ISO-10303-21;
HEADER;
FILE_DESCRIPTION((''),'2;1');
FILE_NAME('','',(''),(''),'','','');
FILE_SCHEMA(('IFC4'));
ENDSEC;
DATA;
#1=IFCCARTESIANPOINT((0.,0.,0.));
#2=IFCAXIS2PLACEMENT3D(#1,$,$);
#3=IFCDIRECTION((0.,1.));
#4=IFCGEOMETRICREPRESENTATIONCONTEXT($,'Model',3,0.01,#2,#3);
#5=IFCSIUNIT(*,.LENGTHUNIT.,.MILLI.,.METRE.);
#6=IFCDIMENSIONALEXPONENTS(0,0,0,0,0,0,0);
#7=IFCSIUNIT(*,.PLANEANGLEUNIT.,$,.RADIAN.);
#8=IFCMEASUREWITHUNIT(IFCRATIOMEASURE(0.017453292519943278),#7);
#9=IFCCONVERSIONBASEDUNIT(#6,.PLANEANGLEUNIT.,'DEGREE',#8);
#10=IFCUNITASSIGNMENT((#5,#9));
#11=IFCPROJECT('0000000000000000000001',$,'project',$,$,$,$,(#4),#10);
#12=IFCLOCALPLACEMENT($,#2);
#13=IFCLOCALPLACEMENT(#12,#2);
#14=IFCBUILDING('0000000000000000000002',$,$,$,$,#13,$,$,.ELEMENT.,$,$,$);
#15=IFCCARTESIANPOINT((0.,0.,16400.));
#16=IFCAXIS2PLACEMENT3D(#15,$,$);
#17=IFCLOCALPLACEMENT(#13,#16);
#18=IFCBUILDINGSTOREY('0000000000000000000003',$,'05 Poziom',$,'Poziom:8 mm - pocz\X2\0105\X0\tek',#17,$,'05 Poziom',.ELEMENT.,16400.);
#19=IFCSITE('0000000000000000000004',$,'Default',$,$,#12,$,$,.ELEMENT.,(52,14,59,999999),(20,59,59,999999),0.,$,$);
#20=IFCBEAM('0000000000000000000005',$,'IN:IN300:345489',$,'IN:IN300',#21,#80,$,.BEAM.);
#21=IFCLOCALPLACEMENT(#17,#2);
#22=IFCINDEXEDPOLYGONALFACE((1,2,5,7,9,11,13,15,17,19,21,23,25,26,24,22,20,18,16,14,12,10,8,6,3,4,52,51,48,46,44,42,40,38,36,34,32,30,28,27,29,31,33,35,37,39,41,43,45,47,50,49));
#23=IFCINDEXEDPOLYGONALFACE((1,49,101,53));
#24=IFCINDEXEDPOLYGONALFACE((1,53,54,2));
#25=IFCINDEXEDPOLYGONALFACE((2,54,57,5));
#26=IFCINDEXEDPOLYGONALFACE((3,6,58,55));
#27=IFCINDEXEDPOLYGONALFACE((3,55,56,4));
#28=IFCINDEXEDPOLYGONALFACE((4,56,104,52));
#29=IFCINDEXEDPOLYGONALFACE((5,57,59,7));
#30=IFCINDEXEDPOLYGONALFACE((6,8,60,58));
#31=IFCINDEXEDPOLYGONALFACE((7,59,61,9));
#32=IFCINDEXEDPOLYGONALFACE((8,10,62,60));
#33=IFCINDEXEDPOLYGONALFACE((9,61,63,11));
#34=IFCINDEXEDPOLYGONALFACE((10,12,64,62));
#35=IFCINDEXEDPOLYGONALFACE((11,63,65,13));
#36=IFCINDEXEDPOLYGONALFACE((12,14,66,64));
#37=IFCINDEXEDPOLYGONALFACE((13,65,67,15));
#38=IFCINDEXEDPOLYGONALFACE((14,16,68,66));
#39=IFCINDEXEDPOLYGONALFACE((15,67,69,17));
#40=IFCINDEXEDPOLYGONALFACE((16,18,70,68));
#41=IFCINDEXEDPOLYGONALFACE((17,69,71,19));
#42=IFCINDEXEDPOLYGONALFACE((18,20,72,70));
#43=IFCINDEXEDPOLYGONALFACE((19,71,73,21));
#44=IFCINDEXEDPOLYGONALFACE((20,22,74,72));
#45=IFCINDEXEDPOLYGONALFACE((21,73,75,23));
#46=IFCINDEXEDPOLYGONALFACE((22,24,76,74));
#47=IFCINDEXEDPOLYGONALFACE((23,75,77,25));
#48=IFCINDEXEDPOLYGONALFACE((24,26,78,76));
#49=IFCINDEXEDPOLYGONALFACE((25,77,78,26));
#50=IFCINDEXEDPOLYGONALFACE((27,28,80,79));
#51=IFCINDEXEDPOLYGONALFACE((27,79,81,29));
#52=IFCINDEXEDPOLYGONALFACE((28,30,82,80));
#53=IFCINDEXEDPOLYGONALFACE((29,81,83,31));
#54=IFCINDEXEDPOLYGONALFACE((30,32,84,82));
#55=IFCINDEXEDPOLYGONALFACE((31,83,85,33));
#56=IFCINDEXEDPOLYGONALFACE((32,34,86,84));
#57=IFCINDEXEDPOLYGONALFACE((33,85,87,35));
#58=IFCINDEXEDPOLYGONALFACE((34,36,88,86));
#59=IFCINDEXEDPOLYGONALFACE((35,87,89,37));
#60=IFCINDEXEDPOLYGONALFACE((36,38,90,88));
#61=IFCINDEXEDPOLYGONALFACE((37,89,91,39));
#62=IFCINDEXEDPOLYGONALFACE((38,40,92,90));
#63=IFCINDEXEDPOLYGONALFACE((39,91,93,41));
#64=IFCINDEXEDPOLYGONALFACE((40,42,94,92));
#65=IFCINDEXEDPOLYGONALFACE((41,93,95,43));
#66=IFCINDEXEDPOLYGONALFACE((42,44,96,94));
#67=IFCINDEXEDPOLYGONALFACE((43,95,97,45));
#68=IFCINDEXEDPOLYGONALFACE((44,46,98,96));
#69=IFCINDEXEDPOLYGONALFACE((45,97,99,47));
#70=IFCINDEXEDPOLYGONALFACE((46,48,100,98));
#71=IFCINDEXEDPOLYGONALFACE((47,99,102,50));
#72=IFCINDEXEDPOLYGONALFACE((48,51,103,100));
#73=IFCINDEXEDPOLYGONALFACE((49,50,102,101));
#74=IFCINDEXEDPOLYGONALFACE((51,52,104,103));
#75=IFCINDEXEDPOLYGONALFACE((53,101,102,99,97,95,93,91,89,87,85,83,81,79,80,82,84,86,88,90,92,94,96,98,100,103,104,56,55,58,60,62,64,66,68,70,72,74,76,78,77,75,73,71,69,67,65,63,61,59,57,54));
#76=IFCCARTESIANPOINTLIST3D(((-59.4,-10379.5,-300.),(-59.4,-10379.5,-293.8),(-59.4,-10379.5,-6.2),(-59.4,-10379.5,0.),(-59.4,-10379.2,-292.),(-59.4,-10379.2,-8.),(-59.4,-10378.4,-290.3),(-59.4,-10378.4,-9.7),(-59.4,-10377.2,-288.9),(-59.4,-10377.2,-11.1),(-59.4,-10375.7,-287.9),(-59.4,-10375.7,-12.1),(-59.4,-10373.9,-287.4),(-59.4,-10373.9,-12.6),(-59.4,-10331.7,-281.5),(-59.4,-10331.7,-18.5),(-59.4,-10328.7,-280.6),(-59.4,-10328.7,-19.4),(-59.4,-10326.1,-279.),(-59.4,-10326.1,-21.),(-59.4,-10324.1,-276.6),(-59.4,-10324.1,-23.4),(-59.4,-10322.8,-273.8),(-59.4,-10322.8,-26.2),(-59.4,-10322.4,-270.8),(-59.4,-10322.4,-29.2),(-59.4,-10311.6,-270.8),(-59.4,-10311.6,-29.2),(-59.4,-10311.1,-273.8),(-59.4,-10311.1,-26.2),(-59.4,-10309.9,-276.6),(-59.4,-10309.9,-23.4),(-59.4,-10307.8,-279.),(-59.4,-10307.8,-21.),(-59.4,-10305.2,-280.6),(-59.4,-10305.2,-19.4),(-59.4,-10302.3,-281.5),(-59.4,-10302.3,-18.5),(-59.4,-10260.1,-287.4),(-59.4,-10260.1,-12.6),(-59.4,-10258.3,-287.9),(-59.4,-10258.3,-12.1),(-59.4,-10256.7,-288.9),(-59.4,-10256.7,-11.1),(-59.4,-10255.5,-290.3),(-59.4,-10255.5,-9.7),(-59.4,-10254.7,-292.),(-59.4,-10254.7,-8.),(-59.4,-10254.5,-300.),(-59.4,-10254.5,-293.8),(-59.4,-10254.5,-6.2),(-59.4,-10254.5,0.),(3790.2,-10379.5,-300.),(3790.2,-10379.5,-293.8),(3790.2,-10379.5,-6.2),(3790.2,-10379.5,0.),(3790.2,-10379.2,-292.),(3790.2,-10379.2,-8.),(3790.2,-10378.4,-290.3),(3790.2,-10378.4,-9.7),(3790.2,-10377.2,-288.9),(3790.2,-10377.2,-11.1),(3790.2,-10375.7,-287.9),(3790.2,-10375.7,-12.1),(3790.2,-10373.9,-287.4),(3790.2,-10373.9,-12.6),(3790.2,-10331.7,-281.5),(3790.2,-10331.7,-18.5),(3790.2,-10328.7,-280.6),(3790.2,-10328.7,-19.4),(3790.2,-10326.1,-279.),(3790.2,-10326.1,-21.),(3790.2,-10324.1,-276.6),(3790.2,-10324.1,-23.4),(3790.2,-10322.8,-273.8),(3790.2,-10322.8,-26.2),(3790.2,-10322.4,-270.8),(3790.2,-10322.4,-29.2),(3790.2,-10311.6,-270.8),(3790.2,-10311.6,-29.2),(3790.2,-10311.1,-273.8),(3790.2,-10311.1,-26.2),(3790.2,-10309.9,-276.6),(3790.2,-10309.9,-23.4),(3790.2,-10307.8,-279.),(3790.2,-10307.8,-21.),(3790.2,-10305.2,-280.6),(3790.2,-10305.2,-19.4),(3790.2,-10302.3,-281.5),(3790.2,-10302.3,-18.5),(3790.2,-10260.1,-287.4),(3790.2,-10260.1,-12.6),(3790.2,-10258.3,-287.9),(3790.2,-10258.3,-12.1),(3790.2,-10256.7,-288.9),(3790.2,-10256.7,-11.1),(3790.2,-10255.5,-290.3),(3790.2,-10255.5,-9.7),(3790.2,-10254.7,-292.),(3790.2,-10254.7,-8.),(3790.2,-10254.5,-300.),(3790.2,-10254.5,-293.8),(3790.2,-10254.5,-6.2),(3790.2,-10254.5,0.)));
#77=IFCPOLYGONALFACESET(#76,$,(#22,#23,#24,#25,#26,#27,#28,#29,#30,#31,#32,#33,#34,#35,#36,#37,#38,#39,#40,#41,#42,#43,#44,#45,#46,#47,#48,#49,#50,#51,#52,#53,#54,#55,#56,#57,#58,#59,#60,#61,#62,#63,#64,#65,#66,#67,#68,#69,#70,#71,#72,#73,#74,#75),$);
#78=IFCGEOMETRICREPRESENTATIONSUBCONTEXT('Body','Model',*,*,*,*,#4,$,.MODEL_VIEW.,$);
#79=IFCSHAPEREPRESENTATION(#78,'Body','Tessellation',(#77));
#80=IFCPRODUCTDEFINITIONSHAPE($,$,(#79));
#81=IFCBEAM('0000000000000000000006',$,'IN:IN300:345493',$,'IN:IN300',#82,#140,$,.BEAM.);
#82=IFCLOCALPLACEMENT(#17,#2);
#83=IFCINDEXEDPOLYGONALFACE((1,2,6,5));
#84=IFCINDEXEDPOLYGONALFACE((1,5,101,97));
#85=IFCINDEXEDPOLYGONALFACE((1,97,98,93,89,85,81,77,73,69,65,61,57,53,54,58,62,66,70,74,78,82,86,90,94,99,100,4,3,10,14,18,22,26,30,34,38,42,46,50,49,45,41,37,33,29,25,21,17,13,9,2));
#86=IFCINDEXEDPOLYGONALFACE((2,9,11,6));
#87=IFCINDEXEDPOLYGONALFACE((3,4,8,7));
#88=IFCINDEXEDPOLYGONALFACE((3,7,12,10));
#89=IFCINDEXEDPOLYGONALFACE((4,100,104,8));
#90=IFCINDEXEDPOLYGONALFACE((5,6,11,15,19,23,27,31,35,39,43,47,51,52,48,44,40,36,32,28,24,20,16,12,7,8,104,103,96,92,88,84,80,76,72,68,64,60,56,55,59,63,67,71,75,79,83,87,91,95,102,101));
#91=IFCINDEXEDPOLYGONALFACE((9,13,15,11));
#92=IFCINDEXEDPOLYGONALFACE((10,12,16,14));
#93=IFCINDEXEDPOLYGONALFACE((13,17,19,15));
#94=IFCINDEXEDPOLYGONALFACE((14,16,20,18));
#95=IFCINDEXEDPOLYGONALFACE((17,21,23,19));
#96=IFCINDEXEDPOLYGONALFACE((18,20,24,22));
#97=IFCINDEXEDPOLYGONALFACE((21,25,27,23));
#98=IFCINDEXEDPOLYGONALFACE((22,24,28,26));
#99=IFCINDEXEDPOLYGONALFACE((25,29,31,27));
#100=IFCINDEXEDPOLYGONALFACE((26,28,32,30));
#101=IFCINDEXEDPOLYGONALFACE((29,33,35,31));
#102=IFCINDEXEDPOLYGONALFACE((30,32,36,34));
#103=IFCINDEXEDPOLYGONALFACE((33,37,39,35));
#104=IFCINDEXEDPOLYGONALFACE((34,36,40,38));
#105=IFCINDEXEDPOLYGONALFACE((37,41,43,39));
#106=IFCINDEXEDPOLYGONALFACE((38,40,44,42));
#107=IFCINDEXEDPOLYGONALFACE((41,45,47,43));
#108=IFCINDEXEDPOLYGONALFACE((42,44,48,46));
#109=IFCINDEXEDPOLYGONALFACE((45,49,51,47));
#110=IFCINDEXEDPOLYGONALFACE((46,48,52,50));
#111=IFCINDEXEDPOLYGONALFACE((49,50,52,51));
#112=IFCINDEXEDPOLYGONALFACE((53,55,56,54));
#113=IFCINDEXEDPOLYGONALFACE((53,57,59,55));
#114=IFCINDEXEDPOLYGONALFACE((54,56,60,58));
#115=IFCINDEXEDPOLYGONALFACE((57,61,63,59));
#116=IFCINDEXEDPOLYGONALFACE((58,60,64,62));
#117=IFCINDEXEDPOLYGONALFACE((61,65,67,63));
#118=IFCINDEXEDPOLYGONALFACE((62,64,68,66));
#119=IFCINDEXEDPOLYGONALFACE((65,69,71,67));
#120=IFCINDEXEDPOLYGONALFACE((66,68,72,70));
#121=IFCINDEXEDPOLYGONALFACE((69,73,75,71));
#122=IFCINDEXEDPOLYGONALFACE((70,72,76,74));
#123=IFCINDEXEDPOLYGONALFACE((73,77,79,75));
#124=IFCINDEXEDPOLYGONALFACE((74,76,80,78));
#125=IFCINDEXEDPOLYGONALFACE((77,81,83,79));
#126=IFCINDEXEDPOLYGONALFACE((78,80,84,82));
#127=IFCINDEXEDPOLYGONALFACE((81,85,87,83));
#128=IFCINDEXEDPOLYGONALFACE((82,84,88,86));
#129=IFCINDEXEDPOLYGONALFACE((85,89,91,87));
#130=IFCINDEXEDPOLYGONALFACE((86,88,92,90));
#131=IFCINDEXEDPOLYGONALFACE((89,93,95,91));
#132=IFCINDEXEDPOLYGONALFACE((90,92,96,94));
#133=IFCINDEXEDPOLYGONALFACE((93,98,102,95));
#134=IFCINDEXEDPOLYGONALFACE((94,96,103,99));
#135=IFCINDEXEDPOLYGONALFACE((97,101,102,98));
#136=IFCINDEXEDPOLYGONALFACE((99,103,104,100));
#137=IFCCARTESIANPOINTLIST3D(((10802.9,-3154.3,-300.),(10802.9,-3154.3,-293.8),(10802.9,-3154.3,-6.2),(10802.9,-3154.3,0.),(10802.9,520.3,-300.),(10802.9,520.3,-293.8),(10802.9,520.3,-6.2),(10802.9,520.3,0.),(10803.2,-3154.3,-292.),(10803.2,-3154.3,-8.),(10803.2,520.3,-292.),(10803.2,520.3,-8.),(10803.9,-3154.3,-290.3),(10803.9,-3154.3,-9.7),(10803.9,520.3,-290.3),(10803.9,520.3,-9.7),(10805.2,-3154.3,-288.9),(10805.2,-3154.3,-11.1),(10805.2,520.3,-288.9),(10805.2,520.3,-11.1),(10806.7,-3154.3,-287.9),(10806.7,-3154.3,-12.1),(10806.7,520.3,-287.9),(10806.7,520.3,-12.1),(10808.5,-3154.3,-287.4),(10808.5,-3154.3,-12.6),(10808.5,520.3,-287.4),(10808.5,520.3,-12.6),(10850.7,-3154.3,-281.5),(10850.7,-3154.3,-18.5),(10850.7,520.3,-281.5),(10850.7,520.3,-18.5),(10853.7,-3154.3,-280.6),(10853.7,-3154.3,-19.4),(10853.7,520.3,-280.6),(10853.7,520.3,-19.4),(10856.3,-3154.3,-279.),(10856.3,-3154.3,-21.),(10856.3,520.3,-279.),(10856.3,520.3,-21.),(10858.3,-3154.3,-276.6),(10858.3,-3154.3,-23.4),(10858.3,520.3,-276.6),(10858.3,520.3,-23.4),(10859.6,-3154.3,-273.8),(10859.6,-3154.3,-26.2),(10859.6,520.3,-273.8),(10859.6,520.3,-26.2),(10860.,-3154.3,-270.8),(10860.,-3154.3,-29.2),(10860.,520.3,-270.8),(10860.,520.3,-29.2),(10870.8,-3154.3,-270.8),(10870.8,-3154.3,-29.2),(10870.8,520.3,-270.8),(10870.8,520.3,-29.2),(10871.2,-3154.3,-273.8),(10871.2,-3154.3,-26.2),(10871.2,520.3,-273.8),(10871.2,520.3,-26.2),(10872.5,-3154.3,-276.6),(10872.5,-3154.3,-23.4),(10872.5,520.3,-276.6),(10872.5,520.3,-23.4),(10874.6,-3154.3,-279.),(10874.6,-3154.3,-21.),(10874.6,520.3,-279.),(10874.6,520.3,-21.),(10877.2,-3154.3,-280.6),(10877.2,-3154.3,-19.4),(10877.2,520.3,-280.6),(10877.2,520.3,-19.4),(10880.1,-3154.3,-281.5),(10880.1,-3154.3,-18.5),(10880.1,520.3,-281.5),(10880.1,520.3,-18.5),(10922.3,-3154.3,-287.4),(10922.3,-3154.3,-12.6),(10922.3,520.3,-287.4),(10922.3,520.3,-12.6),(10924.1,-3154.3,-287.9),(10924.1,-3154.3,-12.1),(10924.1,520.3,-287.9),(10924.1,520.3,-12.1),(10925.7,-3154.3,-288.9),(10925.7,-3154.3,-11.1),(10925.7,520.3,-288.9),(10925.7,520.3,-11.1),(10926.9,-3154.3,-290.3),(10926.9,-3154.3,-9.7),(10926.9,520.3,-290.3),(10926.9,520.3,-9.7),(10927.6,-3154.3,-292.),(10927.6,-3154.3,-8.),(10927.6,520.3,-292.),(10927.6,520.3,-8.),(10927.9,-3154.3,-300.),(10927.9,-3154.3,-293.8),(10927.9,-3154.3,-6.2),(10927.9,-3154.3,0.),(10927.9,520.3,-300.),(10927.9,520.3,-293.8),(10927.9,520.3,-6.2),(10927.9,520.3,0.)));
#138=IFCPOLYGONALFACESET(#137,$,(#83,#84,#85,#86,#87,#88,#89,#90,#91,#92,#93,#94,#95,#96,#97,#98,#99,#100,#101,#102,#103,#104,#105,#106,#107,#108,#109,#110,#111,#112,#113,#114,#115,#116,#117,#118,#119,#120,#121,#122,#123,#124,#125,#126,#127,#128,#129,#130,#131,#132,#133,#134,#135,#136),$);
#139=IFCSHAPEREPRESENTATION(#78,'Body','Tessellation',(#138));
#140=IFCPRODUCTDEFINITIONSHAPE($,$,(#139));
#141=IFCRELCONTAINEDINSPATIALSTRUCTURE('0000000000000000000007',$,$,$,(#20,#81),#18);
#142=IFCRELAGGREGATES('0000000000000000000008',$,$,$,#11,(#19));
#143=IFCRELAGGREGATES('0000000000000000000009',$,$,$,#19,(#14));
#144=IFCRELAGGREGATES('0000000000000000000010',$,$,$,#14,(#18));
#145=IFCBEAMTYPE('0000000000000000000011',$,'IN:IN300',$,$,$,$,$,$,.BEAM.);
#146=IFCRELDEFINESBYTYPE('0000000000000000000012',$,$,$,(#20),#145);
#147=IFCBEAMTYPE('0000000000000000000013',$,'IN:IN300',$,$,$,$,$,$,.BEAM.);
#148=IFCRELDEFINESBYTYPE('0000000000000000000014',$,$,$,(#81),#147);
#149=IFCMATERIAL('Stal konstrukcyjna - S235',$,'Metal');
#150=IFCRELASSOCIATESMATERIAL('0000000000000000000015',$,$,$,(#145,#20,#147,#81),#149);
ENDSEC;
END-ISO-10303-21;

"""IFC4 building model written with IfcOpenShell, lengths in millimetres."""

from ifc_helpers import new_model, entity, si_unit, converted_unit, direction, frame, origin, place, context, subcontext, project, spatial, line, arc, indexed_curve, outline, extrude, source, transform, mapped, material, type_object, type_shapes, element, save


model = new_model("IFC4")

# Units and contexts
model_context = context("Model", 3, precision=0.01, world=origin(), true_north=direction((0.0, 1.0)))
body_context = subcontext(model_context, "Body", "Model", "MODEL_VIEW")
ifc_project = project(units=[si_unit("LENGTHUNIT", "METRE", prefix="MILLI"), converted_unit("PLANEANGLEUNIT", "DEGREE", entity("IfcRatioMeasure", 0.017453292519943278), si_unit("PLANEANGLEUNIT", "RADIAN"), dimensions=[0, 0, 0, 0, 0, 0, 0])], contexts=[model_context])

# Site, building, storey
site_placement = place(None, origin())
site = spatial("IfcSite", under=ifc_project, at=site_placement, Name="Default", CompositionType="ELEMENT", RefLatitude=(52, 14, 59, 999999), RefLongitude=(20, 59, 59, 999999), RefElevation=0.0)
building_placement = place(site_placement, origin())
building = spatial("IfcBuilding", under=site, at=building_placement, CompositionType="ELEMENT")
storey_placement = place(building_placement, frame((0.0, 0.0, 16400.0)))
storey = spatial("IfcBuildingStorey", under=building, at=storey_placement, Name="05 Poziom", ObjectType="Poziom:8 mm - początek", LongName="05 Poziom", CompositionType="ELEMENT", Elevation=16400.0)

# Shared definitions
ifc_material = material(Name="Stal konstrukcyjna - S235", Category="Metal")

# Beams
beam_type_1 = type_object("IfcBeamType", Name="IN:IN300", PredefinedType="BEAM", material=ifc_material)
shared_shape_1 = source(origin(), body_context, "Body", "SweptSolid", [
    extrude(outline(indexed_curve([(143.8, -62.5), (150.0, -62.5), (150.0, 62.5), (143.8, 62.5), (139.6, 60.9), (137.4, 56.9), (131.5, 14.7), (127.9, 8.1), (120.8, 5.4), (-120.8, 5.4), (-127.9, 8.1), (-131.5, 14.7), (-137.4, 56.9), (-139.6, 60.9), (-143.8, 62.5), (-150.0, 62.5), (-150.0, -62.5), (-143.8, -62.5), (-139.6, -60.9), (-137.4, -56.9), (-131.5, -14.7), (-127.9, -8.1), (-120.8, -5.4), (120.8, -5.4), (127.9, -8.1), (131.5, -14.7), (137.4, -56.9), (139.6, -60.9)], segments=[line(1, 2, 3, 4), arc(4, 5, 6), line(6, 7), arc(7, 8, 9), line(9, 10), arc(10, 11, 12), line(12, 13), arc(13, 14, 15), line(15, 16, 17, 18), arc(18, 19, 20), line(20, 21), arc(21, 22, 23), line(23, 24), arc(24, 25, 26), line(26, 27), arc(27, 28, 1)], self_intersect=False)), frame((-1924.8, 0.0, 0.0), z_axis=(1.0, 0.0, 0.0), x_axis=(0.0, 0.0, -1.0)), (0.0, 0.0, 1.0), 3849.6),
])
type_shapes(beam_type_1, [shared_shape_1])
for number, where, name in (
    (1, (1865.4, -10317.0, -150.0), "IN:IN300:345489"),
):
    element("IfcBeam", number, at=place(storey_placement, frame(where)), inside=storey, type_object=beam_type_1, material=ifc_material, Name=name, ObjectType="IN:IN300", PredefinedType="BEAM", context=body_context, shape_type="MappedRepresentation", body=[
        mapped(shared_shape_1, transform((0.0, 0.0, 0.0), scale=1.0)),
    ])
beam_type_2 = type_object("IfcBeamType", Name="IN:IN300", PredefinedType="BEAM", material=ifc_material)
shared_shape_2 = source(origin(), body_context, "Body", "SweptSolid", [
    extrude(outline(indexed_curve([(143.8, -62.5), (150.0, -62.5), (150.0, 62.5), (143.8, 62.5), (139.6, 60.9), (137.4, 56.9), (131.5, 14.7), (127.9, 8.1), (120.8, 5.4), (-120.8, 5.4), (-127.9, 8.1), (-131.5, 14.7), (-137.4, 56.9), (-139.6, 60.9), (-143.8, 62.5), (-150.0, 62.5), (-150.0, -62.5), (-143.8, -62.5), (-139.6, -60.9), (-137.4, -56.9), (-131.5, -14.7), (-127.9, -8.1), (-120.8, -5.4), (120.8, -5.4), (127.9, -8.1), (131.5, -14.7), (137.4, -56.9), (139.6, -60.9)], segments=[line(1, 2, 3, 4), arc(4, 5, 6), line(6, 7), arc(7, 8, 9), line(9, 10), arc(10, 11, 12), line(12, 13), arc(13, 14, 15), line(15, 16, 17, 18), arc(18, 19, 20), line(20, 21), arc(21, 22, 23), line(23, 24), arc(24, 25, 26), line(26, 27), arc(27, 28, 1)], self_intersect=False)), frame((-1837.3, 0.0, 0.0), z_axis=(1.0, 0.0, 0.0), x_axis=(0.0, 0.0, -1.0)), (0.0, 0.0, 1.0), 3674.6),
])
type_shapes(beam_type_2, [shared_shape_2])
for number, where, z_axis, x_axis, name in (
    (2, (10865.4, -1317.0, -150.0), (0.0, 0.0, 1.0), (0.0, -1.0, 0.0), "IN:IN300:345493"),
):
    element("IfcBeam", number, at=place(storey_placement, frame(where, z_axis=z_axis, x_axis=x_axis)), inside=storey, type_object=beam_type_2, material=ifc_material, Name=name, ObjectType="IN:IN300", PredefinedType="BEAM", context=body_context, shape_type="MappedRepresentation", body=[
        mapped(shared_shape_2, transform((0.0, 0.0, 0.0), scale=1.0)),
    ])

save(model, "model.ifc")
